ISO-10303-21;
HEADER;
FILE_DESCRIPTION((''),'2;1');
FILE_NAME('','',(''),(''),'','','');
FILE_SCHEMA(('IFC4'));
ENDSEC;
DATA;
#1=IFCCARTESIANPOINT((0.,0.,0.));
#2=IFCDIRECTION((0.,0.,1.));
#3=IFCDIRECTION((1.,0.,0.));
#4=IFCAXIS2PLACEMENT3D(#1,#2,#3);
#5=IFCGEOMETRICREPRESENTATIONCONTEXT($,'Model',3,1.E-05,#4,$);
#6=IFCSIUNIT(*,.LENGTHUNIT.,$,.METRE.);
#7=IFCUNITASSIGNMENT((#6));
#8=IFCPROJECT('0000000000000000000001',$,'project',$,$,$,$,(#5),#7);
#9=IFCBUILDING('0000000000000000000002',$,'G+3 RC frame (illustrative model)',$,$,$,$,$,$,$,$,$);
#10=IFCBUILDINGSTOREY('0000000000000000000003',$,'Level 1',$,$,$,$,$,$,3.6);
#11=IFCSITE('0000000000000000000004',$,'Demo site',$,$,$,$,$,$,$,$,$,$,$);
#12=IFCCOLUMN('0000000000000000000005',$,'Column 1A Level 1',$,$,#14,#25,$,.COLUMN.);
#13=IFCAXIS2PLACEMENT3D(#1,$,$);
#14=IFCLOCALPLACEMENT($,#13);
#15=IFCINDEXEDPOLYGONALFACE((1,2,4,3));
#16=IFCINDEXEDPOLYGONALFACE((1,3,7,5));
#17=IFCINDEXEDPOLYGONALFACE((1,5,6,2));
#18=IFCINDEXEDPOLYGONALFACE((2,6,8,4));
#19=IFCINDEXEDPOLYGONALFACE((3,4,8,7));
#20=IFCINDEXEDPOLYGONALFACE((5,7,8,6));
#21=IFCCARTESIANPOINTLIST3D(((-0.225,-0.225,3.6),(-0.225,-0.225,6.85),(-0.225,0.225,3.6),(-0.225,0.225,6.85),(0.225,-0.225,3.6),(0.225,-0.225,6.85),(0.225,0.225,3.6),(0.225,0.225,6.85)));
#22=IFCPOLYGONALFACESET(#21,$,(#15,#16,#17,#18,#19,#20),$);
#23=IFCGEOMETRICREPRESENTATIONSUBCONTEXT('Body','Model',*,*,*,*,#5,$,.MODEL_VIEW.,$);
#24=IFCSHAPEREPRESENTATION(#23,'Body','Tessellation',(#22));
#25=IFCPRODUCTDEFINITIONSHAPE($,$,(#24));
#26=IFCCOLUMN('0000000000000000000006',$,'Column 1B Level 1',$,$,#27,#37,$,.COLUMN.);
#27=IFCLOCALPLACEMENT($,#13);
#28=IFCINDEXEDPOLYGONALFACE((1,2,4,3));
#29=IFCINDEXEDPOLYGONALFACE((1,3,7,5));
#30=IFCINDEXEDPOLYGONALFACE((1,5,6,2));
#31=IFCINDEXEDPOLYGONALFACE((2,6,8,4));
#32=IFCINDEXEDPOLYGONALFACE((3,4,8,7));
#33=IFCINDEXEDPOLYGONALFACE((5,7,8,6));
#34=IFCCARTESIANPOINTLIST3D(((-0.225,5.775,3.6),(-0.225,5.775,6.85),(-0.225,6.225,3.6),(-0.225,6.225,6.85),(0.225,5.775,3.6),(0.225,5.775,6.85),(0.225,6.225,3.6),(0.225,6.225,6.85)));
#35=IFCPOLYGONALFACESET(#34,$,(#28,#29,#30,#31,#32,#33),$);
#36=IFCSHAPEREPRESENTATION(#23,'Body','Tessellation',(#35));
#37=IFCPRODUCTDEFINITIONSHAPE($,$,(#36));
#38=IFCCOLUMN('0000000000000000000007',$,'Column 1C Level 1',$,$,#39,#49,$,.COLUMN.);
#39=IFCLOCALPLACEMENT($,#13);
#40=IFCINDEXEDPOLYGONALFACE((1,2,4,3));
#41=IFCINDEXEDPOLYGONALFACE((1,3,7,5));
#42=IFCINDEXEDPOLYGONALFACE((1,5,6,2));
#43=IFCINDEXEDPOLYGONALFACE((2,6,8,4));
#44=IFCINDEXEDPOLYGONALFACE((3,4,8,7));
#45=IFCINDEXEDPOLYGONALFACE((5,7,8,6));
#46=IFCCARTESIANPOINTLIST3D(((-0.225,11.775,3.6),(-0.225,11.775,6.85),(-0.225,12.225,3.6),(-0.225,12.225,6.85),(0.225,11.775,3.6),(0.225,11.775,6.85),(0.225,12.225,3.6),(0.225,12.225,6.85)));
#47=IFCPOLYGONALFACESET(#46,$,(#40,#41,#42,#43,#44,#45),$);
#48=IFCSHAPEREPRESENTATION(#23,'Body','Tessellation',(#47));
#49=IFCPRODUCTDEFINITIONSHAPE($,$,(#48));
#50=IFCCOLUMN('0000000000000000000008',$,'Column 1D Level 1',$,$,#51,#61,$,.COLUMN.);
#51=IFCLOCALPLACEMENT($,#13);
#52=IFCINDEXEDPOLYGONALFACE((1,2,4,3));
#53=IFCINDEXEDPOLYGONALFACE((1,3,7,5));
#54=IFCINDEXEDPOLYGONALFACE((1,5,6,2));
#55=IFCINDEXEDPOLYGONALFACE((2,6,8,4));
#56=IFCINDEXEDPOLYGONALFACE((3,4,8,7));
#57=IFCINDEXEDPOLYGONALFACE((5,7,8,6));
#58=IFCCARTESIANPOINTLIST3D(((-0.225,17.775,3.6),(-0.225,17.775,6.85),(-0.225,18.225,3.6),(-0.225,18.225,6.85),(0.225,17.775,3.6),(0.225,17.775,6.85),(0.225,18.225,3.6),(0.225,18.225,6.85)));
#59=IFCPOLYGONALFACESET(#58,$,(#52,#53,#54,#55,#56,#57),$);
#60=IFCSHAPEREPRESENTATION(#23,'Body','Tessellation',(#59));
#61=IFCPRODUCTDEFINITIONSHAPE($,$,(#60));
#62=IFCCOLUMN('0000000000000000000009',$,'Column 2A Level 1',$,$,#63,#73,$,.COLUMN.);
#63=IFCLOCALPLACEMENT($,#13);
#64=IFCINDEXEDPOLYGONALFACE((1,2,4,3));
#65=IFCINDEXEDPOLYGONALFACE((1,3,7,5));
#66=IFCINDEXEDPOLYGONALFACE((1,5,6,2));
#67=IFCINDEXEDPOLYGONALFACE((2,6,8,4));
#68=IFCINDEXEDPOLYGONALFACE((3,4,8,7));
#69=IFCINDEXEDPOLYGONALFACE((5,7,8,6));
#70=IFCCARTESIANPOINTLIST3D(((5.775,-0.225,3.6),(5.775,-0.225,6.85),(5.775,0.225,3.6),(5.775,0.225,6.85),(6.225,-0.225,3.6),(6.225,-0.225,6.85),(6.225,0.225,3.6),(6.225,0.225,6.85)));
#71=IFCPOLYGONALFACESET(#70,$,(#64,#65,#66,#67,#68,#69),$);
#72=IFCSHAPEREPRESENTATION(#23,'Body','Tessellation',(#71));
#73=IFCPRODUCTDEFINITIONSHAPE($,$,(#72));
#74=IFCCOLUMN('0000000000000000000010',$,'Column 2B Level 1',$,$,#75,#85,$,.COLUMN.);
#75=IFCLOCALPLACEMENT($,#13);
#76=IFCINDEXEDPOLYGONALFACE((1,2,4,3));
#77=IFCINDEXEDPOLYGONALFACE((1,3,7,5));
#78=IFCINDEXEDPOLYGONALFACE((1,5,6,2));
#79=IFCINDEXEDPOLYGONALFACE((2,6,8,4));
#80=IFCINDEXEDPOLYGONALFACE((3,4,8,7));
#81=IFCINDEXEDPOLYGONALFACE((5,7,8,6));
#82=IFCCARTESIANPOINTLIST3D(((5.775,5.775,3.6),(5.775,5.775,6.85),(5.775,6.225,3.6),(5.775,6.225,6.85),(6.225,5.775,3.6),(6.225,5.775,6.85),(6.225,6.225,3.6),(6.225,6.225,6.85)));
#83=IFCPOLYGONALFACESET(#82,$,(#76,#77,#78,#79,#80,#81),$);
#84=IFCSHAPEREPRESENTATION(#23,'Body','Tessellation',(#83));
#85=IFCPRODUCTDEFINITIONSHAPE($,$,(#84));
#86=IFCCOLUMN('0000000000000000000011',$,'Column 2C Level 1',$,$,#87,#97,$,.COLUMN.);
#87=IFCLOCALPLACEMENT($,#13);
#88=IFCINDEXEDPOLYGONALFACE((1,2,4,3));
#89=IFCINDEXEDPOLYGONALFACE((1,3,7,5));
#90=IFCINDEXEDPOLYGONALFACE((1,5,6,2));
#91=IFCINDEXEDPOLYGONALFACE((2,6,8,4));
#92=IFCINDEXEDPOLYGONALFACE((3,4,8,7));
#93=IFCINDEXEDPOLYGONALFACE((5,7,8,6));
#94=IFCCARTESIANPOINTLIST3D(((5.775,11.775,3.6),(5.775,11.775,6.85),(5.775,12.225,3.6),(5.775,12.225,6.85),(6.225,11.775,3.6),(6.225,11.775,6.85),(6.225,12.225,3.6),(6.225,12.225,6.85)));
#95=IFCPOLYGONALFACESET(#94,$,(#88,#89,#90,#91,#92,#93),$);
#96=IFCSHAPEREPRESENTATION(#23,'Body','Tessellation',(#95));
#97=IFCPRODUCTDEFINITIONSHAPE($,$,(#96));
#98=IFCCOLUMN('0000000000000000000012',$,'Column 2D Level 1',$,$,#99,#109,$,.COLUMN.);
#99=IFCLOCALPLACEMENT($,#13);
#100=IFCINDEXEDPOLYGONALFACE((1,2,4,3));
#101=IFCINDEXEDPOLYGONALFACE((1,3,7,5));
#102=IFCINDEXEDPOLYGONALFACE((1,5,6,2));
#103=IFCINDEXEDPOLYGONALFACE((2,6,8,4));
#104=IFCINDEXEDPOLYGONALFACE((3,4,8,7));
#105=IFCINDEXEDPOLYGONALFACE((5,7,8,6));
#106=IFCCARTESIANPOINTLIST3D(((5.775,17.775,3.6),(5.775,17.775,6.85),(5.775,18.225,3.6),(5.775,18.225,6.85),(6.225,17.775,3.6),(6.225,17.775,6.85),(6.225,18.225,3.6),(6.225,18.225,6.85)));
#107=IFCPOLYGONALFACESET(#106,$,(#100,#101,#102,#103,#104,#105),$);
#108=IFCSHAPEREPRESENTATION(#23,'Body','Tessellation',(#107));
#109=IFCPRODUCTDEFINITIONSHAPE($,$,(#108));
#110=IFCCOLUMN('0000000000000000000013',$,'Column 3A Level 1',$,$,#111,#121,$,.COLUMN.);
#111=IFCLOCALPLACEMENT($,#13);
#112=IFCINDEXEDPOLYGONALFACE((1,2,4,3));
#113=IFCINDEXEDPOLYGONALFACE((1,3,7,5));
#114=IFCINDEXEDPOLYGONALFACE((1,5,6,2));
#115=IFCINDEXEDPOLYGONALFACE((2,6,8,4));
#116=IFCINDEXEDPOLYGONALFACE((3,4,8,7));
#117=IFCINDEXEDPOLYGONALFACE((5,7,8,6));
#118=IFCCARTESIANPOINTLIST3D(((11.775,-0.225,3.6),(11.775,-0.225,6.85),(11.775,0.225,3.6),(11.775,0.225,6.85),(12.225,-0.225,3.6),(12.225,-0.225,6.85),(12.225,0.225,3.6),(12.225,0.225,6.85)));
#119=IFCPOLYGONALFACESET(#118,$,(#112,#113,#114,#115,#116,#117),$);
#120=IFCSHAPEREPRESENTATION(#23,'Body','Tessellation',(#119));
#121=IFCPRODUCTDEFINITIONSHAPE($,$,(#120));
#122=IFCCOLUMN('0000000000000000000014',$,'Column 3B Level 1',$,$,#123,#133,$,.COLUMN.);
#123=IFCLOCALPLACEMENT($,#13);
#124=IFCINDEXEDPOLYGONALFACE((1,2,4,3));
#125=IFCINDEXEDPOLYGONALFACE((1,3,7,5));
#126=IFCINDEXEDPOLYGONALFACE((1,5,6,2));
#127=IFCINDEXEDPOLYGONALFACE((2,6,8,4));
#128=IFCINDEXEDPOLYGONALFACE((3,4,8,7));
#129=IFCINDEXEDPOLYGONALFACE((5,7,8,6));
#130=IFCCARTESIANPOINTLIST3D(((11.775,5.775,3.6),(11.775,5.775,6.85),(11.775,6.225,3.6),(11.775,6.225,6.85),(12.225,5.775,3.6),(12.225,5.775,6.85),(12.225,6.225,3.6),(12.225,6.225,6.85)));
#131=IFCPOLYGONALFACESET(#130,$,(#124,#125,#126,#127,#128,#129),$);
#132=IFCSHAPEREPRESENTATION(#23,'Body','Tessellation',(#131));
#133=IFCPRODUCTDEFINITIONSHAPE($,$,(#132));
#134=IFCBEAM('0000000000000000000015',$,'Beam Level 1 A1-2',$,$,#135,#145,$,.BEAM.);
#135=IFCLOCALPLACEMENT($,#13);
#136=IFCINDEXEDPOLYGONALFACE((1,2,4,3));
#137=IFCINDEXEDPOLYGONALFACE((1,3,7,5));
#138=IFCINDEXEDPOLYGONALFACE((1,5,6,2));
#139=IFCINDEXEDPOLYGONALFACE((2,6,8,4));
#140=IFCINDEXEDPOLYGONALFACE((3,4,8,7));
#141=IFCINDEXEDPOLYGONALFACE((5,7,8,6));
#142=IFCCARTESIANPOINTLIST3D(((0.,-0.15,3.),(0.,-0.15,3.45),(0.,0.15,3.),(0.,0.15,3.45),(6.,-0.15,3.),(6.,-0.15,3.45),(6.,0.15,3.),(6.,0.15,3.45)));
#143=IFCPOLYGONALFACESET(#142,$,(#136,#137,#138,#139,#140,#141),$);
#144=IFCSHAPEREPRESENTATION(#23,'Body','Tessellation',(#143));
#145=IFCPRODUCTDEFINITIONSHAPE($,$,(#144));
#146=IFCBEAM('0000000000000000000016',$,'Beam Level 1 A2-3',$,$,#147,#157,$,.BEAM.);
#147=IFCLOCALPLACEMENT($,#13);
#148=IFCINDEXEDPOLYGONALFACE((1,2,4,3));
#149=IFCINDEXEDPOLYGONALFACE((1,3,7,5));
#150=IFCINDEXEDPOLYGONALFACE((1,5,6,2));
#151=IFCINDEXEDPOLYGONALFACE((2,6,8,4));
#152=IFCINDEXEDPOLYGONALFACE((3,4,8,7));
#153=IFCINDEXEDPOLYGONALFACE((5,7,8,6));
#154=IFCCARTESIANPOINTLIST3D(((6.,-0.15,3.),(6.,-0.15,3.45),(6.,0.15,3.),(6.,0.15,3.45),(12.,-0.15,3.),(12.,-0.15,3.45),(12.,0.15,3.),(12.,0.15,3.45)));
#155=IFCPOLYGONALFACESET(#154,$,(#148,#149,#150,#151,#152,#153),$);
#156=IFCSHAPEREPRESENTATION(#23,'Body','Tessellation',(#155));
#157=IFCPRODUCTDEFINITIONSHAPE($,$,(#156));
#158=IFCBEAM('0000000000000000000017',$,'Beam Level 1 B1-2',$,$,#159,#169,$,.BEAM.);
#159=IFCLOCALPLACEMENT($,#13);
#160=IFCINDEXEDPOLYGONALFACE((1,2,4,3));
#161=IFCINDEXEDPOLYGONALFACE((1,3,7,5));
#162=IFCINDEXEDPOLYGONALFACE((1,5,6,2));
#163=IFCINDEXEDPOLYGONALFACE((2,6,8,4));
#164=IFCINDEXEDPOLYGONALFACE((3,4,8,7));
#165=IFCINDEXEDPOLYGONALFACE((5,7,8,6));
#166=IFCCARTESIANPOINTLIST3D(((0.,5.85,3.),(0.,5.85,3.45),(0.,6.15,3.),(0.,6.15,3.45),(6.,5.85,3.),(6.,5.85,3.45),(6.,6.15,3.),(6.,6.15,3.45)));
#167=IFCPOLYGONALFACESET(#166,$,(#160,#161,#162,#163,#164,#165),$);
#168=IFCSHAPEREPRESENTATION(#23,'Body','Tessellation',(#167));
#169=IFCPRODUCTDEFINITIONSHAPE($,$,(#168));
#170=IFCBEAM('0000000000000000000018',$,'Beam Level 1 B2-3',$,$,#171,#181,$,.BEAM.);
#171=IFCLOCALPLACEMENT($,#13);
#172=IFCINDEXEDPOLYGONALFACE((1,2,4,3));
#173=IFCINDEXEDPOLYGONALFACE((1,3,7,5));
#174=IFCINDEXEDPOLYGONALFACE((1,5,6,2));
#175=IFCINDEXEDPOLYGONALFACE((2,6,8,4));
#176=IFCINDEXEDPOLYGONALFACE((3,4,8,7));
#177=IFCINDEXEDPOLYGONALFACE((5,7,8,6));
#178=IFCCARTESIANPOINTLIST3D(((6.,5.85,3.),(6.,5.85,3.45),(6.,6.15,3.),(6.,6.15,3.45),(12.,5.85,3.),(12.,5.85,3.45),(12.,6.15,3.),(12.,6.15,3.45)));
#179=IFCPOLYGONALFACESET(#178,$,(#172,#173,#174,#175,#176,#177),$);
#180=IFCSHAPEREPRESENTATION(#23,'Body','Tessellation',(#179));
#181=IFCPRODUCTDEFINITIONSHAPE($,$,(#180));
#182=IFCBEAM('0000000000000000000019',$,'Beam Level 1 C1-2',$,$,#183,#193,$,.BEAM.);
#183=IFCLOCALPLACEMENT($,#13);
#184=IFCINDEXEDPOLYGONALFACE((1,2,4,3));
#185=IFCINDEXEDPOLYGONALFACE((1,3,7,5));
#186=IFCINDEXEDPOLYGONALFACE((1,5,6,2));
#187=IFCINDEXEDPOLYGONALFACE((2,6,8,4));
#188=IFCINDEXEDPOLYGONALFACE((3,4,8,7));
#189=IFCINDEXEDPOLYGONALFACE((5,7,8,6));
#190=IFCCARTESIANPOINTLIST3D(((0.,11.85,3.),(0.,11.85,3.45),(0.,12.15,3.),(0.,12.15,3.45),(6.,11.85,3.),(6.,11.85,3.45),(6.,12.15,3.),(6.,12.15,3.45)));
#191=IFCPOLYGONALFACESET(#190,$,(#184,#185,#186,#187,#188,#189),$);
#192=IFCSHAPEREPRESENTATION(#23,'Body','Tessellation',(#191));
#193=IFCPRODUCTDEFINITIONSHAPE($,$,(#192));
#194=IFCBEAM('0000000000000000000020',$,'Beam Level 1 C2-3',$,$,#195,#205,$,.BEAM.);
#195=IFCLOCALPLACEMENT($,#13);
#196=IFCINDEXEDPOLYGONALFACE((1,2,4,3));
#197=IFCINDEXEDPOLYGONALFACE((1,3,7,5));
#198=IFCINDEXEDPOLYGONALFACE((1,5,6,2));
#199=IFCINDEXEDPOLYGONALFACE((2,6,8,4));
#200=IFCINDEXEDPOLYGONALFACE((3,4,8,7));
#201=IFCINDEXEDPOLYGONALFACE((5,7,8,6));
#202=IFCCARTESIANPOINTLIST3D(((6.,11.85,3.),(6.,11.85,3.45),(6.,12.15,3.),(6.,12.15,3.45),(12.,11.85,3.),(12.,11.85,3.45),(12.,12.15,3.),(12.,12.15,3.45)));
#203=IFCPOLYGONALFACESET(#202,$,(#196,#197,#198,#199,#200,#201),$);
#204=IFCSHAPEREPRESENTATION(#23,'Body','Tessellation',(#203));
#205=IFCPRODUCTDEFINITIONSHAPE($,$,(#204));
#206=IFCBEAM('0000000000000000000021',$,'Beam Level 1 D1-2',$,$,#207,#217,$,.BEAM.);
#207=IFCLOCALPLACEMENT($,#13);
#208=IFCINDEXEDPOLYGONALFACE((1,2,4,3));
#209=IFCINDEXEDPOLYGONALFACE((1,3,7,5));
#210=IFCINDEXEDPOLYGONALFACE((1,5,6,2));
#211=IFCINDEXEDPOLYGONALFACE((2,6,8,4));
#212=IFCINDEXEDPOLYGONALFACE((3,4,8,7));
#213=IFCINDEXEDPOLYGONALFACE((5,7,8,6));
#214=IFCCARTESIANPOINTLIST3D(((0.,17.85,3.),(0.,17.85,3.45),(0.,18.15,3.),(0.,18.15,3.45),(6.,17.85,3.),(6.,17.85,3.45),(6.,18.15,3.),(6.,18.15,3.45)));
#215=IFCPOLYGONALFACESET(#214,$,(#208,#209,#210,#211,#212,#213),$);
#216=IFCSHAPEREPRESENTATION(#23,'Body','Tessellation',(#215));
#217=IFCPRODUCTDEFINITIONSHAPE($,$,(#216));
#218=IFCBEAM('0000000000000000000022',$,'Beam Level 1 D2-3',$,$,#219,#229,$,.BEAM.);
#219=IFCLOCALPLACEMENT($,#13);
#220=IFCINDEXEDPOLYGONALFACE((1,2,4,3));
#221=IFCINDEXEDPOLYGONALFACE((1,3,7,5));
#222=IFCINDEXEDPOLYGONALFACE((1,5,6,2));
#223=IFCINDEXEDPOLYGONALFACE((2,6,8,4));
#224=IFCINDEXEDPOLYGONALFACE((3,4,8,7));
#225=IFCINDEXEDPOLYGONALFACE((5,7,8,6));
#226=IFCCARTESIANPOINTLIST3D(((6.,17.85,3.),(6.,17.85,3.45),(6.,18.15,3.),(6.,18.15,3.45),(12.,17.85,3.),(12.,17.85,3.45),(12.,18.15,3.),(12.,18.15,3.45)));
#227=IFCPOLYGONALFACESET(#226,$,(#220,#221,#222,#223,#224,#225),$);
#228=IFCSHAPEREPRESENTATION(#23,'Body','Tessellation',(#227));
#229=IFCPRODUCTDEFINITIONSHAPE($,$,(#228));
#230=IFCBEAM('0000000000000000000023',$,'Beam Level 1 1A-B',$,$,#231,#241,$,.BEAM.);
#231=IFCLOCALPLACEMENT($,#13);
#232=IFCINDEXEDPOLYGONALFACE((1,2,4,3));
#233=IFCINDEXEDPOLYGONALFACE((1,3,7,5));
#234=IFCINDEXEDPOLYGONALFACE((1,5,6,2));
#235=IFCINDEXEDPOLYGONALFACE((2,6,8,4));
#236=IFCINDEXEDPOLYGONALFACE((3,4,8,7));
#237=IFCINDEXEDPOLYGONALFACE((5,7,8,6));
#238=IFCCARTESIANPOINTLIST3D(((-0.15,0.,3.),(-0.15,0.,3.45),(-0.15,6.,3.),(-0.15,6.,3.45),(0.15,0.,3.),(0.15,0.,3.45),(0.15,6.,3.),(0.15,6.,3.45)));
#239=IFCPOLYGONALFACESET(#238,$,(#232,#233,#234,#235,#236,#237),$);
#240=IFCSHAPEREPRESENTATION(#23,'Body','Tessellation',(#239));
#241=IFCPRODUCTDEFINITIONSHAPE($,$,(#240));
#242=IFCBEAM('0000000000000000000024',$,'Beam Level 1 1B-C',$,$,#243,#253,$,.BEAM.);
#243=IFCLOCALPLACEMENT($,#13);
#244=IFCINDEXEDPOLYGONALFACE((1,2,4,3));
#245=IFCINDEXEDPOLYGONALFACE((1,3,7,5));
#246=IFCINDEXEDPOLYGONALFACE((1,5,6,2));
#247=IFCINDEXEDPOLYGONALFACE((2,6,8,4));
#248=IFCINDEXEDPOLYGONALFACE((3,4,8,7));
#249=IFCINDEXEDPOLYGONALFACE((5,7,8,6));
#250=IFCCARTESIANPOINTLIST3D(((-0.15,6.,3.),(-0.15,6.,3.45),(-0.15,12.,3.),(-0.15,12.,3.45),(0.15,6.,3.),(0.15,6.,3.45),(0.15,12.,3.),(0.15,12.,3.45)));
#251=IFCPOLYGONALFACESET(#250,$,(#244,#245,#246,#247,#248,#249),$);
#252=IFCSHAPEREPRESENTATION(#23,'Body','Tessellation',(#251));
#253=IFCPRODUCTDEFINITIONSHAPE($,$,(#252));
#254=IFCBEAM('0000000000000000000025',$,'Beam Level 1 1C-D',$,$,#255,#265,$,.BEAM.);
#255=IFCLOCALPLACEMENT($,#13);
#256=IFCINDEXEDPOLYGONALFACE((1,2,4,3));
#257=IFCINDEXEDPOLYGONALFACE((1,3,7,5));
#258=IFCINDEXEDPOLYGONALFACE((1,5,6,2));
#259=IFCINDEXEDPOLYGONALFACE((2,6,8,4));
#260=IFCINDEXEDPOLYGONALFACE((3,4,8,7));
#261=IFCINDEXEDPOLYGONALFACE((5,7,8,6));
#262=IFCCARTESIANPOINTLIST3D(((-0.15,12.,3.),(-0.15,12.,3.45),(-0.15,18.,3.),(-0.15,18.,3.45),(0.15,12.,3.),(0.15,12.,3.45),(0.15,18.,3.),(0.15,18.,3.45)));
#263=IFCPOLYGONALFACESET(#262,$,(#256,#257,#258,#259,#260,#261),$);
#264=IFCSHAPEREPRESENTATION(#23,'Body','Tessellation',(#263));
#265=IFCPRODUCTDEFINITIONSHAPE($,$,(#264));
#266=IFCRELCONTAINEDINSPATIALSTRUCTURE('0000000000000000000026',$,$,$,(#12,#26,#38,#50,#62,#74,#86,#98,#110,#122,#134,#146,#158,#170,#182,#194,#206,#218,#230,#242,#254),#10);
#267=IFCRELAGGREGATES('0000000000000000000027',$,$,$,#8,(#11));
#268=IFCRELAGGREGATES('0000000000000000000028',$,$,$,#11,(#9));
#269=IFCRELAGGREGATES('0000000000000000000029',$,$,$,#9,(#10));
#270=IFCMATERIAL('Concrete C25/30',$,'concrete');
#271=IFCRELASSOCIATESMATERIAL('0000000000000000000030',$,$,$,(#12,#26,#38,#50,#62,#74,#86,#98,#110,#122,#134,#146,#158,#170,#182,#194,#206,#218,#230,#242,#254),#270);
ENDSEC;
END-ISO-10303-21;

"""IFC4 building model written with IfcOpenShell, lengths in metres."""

from ifc_helpers import new_model, si_unit, frame, frame_2d, origin, origin_with_axes, place, context, subcontext, project, spatial, rectangle, extrude, material, element, save


model = new_model("IFC4")

# Units and contexts
model_context = context("Model", 3, precision=1e-05, world=origin_with_axes())
body_context = subcontext(model_context, "Body", "Model", "MODEL_VIEW")
ifc_project = project(units=[si_unit("LENGTHUNIT", "METRE")], contexts=[model_context])

# Site, building, storey
site = spatial("IfcSite", under=ifc_project, Name="Demo site")
building = spatial("IfcBuilding", under=site, Name="G+3 RC frame (illustrative model)")
storey = spatial("IfcBuildingStorey", under=building, Name="Level 1", Elevation=3.6)

# Columns
ifc_material_1 = material(Name="Concrete C25/30", Category="concrete")
for number, where, z_axis, x_axis, name in (
    (1, (-0.225, -0.225, 3.6), (0.0, 0.0, 1.0), (1.0, 0.0, 0.0), "Column 1A Level 1"),
    (2, (-0.225, 5.775, 3.6), (0.0, 0.0, 1.0), (1.0, 0.0, 0.0), "Column 1B Level 1"),
    (3, (-0.225, 11.775, 3.6), (0.0, 0.0, 1.0), (1.0, 0.0, 0.0), "Column 1C Level 1"),
    (4, (-0.225, 17.775, 3.6), (0.0, 0.0, 1.0), (1.0, 0.0, 0.0), "Column 1D Level 1"),
    (5, (5.775, -0.225, 3.6), (0.0, 0.0, 1.0), (1.0, 0.0, 0.0), "Column 2A Level 1"),
    (6, (5.775, 5.775, 3.6), (0.0, 0.0, 1.0), (1.0, 0.0, 0.0), "Column 2B Level 1"),
    (7, (5.775, 11.775, 3.6), (0.0, 0.0, 1.0), (1.0, 0.0, 0.0), "Column 2C Level 1"),
    (8, (5.775, 17.775, 3.6), (0.0, 0.0, 1.0), (1.0, 0.0, 0.0), "Column 2D Level 1"),
    (9, (11.775, -0.225, 3.6), (0.0, 0.0, 1.0), (1.0, 0.0, 0.0), "Column 3A Level 1"),
    (10, (11.775, 5.775, 3.6), (0.0, 0.0, 1.0), (1.0, 0.0, 0.0), "Column 3B Level 1"),
):
    element("IfcColumn", number, at=place(None, frame(where, z_axis=z_axis, x_axis=x_axis)), inside=storey, material=ifc_material_1, Name=name, PredefinedType="COLUMN", context=body_context, shape_type="SweptSolid", body=[
        extrude(rectangle(XDim=0.45, YDim=0.45, at=frame_2d((0.225, 0.225))), origin(), (0.0, 0.0, 1.0), 3.25),
    ])

# Beams
for number, where, z_axis, x_axis, name in (
    (11, (0.0, -0.15, 3.0), (0.0, 0.0, 1.0), (1.0, 0.0, 0.0), "Beam Level 1 A1-2"),
    (12, (6.0, -0.15, 3.0), (0.0, 0.0, 1.0), (1.0, 0.0, 0.0), "Beam Level 1 A2-3"),
    (13, (0.0, 5.85, 3.0), (0.0, 0.0, 1.0), (1.0, 0.0, 0.0), "Beam Level 1 B1-2"),
    (14, (6.0, 5.85, 3.0), (0.0, 0.0, 1.0), (1.0, 0.0, 0.0), "Beam Level 1 B2-3"),
    (15, (0.0, 11.85, 3.0), (0.0, 0.0, 1.0), (1.0, 0.0, 0.0), "Beam Level 1 C1-2"),
    (16, (6.0, 11.85, 3.0), (0.0, 0.0, 1.0), (1.0, 0.0, 0.0), "Beam Level 1 C2-3"),
    (17, (0.0, 17.85, 3.0), (0.0, 0.0, 1.0), (1.0, 0.0, 0.0), "Beam Level 1 D1-2"),
    (18, (6.0, 17.85, 3.0), (0.0, 0.0, 1.0), (1.0, 0.0, 0.0), "Beam Level 1 D2-3"),
):
    element("IfcBeam", number, at=place(None, frame(where, z_axis=z_axis, x_axis=x_axis)), inside=storey, material=ifc_material_1, Name=name, PredefinedType="BEAM", context=body_context, shape_type="SweptSolid", body=[
        extrude(rectangle(XDim=6.0, YDim=0.3, at=frame_2d((3.0, 0.15))), origin(), (0.0, 0.0, 1.0), 0.45),
    ])
for number, where, z_axis, x_axis, name in (
    (19, (-0.15, 0.0, 3.0), (0.0, 0.0, 1.0), (1.0, 0.0, 0.0), "Beam Level 1 1A-B"),
    (20, (-0.15, 6.0, 3.0), (0.0, 0.0, 1.0), (1.0, 0.0, 0.0), "Beam Level 1 1B-C"),
    (21, (-0.15, 12.0, 3.0), (0.0, 0.0, 1.0), (1.0, 0.0, 0.0), "Beam Level 1 1C-D"),
):
    element("IfcBeam", number, at=place(None, frame(where, z_axis=z_axis, x_axis=x_axis)), inside=storey, material=ifc_material_1, Name=name, PredefinedType="BEAM", context=body_context, shape_type="SweptSolid", body=[
        extrude(rectangle(XDim=0.3, YDim=6.0, at=frame_2d((0.15, 3.0))), origin(), (0.0, 0.0, 1.0), 0.45),
    ])

save(model, "model.ifc")
